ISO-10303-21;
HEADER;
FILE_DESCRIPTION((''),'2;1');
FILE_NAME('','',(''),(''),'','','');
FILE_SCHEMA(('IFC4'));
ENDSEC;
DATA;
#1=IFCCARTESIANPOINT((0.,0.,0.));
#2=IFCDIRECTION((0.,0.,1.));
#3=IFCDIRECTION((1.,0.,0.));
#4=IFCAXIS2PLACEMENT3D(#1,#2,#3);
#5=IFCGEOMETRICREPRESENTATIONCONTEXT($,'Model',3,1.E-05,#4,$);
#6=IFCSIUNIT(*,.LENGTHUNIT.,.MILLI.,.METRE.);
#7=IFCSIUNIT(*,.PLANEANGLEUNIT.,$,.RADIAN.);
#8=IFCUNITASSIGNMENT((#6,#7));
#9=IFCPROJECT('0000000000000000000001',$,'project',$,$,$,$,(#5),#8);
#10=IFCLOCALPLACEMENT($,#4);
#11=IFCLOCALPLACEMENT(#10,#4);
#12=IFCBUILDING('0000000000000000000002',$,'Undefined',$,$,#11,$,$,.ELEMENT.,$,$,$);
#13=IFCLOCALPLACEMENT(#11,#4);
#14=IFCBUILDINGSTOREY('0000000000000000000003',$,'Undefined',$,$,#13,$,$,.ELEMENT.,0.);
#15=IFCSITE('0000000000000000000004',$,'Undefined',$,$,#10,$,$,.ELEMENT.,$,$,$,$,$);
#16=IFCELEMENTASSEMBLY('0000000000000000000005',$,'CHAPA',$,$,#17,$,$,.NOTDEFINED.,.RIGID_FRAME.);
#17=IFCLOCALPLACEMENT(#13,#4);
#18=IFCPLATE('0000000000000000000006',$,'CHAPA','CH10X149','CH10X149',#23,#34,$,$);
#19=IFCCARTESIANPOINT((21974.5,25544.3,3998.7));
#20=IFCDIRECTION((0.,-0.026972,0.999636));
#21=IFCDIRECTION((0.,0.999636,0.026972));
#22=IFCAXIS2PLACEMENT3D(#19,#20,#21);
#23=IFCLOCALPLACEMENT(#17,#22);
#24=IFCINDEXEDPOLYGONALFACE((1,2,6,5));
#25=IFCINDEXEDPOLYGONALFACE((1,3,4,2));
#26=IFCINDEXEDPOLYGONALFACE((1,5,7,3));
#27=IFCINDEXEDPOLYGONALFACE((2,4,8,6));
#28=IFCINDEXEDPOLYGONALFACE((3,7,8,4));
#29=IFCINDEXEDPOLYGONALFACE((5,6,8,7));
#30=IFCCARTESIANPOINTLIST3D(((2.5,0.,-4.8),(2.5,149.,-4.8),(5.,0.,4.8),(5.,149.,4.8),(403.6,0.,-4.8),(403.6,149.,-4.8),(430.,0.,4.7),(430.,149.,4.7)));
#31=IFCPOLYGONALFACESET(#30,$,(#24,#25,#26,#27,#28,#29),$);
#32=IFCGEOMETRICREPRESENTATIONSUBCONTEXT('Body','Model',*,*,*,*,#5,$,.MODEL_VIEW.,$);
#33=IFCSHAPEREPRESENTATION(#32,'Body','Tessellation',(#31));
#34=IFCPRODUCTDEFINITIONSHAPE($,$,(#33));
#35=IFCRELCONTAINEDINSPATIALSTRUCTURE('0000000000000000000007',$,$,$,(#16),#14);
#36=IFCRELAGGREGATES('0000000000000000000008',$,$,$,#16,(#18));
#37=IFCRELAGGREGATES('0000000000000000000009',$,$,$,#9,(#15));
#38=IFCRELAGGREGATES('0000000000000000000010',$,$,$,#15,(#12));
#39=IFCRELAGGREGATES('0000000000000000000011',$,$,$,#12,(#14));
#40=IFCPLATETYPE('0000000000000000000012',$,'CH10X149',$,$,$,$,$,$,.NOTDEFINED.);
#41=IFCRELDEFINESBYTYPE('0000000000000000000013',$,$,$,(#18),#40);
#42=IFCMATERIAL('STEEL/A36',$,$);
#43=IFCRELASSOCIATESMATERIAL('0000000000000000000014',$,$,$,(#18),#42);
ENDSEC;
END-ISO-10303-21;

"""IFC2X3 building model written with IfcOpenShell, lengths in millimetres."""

from ifc_helpers import new_model, si_unit, frame, origin_with_axes, place, context, subcontext, project, spatial, polyline, outline, extrude, clip, halfspace, material, type_object, element, aggregate, save


model = new_model("IFC2X3")

# Units and contexts
model_context = context("Model", 3, precision=1e-05, world=origin_with_axes())
body_context = subcontext(model_context, "Body", "Model", "MODEL_VIEW")
ifc_project = project(units=[si_unit("LENGTHUNIT", "METRE", prefix="MILLI"), si_unit("PLANEANGLEUNIT", "RADIAN")], contexts=[model_context])

# Site, building, storey
site_placement = place(None, origin_with_axes())
site = spatial("IfcSite", under=ifc_project, at=site_placement, Name="Undefined", CompositionType="ELEMENT")
building_placement = place(site_placement, origin_with_axes())
building = spatial("IfcBuilding", under=site, at=building_placement, Name="Undefined", CompositionType="ELEMENT")
storey_placement = place(building_placement, origin_with_axes())
storey = spatial("IfcBuildingStorey", under=building, at=storey_placement, Name="Undefined", CompositionType="ELEMENT", Elevation=0.0)

# Shared definitions
ifc_material_1 = material(Name="STEEL/A36")

# Element assembly, plate
plate_type_1 = type_object("IfcPlateType", Name="CH10X149", PredefinedType="NOTDEFINED")
assembly_1_placement = place(storey_placement, origin_with_axes())
assembly_1 = element("IfcElementAssembly", 1, at=assembly_1_placement, inside=storey, Name="CHAPA", AssemblyPlace="NOTDEFINED", PredefinedType="RIGID_FRAME")
plate_1_placement = place(assembly_1_placement, frame((21974.5, 25544.3, 3998.7), z_axis=(0.0, -0.026972, 0.999636), x_axis=(0.0, 0.999636, 0.026972)))
plate_1 = element("IfcPlate", 2, at=plate_1_placement, type_object=plate_type_1, material=ifc_material_1, Name="CHAPA", Description="CH10X149", ObjectType="CH10X149", context=body_context, shape_type="Clipping", body=[
    clip(clip(extrude(outline(polyline([(0.0, 0.0), (430.0, 0.0), (430.0, 149.0), (0.0, 149.0), (0.0, 0.0)])), frame((0.0, 0.0, -4.8), z_axis=(0.0, 0.0, 1.0), x_axis=(1.0, 0.0, 0.0)), (0.0, 0.0, 1.0), 9.5), halfspace(frame((403.6, -500.0, -4.8), z_axis=(0.33881, 0.0, -0.940855), x_axis=(0.940855, 0.0, 0.33881)), False)), halfspace(frame((5.0, -500.0, 4.7), z_axis=(-0.965989, 0.0, 0.258583), x_axis=(-0.258583, 0.0, -0.965989)), False)),
])
aggregate(assembly_1, [plate_1])

save(model, "model.ifc")
